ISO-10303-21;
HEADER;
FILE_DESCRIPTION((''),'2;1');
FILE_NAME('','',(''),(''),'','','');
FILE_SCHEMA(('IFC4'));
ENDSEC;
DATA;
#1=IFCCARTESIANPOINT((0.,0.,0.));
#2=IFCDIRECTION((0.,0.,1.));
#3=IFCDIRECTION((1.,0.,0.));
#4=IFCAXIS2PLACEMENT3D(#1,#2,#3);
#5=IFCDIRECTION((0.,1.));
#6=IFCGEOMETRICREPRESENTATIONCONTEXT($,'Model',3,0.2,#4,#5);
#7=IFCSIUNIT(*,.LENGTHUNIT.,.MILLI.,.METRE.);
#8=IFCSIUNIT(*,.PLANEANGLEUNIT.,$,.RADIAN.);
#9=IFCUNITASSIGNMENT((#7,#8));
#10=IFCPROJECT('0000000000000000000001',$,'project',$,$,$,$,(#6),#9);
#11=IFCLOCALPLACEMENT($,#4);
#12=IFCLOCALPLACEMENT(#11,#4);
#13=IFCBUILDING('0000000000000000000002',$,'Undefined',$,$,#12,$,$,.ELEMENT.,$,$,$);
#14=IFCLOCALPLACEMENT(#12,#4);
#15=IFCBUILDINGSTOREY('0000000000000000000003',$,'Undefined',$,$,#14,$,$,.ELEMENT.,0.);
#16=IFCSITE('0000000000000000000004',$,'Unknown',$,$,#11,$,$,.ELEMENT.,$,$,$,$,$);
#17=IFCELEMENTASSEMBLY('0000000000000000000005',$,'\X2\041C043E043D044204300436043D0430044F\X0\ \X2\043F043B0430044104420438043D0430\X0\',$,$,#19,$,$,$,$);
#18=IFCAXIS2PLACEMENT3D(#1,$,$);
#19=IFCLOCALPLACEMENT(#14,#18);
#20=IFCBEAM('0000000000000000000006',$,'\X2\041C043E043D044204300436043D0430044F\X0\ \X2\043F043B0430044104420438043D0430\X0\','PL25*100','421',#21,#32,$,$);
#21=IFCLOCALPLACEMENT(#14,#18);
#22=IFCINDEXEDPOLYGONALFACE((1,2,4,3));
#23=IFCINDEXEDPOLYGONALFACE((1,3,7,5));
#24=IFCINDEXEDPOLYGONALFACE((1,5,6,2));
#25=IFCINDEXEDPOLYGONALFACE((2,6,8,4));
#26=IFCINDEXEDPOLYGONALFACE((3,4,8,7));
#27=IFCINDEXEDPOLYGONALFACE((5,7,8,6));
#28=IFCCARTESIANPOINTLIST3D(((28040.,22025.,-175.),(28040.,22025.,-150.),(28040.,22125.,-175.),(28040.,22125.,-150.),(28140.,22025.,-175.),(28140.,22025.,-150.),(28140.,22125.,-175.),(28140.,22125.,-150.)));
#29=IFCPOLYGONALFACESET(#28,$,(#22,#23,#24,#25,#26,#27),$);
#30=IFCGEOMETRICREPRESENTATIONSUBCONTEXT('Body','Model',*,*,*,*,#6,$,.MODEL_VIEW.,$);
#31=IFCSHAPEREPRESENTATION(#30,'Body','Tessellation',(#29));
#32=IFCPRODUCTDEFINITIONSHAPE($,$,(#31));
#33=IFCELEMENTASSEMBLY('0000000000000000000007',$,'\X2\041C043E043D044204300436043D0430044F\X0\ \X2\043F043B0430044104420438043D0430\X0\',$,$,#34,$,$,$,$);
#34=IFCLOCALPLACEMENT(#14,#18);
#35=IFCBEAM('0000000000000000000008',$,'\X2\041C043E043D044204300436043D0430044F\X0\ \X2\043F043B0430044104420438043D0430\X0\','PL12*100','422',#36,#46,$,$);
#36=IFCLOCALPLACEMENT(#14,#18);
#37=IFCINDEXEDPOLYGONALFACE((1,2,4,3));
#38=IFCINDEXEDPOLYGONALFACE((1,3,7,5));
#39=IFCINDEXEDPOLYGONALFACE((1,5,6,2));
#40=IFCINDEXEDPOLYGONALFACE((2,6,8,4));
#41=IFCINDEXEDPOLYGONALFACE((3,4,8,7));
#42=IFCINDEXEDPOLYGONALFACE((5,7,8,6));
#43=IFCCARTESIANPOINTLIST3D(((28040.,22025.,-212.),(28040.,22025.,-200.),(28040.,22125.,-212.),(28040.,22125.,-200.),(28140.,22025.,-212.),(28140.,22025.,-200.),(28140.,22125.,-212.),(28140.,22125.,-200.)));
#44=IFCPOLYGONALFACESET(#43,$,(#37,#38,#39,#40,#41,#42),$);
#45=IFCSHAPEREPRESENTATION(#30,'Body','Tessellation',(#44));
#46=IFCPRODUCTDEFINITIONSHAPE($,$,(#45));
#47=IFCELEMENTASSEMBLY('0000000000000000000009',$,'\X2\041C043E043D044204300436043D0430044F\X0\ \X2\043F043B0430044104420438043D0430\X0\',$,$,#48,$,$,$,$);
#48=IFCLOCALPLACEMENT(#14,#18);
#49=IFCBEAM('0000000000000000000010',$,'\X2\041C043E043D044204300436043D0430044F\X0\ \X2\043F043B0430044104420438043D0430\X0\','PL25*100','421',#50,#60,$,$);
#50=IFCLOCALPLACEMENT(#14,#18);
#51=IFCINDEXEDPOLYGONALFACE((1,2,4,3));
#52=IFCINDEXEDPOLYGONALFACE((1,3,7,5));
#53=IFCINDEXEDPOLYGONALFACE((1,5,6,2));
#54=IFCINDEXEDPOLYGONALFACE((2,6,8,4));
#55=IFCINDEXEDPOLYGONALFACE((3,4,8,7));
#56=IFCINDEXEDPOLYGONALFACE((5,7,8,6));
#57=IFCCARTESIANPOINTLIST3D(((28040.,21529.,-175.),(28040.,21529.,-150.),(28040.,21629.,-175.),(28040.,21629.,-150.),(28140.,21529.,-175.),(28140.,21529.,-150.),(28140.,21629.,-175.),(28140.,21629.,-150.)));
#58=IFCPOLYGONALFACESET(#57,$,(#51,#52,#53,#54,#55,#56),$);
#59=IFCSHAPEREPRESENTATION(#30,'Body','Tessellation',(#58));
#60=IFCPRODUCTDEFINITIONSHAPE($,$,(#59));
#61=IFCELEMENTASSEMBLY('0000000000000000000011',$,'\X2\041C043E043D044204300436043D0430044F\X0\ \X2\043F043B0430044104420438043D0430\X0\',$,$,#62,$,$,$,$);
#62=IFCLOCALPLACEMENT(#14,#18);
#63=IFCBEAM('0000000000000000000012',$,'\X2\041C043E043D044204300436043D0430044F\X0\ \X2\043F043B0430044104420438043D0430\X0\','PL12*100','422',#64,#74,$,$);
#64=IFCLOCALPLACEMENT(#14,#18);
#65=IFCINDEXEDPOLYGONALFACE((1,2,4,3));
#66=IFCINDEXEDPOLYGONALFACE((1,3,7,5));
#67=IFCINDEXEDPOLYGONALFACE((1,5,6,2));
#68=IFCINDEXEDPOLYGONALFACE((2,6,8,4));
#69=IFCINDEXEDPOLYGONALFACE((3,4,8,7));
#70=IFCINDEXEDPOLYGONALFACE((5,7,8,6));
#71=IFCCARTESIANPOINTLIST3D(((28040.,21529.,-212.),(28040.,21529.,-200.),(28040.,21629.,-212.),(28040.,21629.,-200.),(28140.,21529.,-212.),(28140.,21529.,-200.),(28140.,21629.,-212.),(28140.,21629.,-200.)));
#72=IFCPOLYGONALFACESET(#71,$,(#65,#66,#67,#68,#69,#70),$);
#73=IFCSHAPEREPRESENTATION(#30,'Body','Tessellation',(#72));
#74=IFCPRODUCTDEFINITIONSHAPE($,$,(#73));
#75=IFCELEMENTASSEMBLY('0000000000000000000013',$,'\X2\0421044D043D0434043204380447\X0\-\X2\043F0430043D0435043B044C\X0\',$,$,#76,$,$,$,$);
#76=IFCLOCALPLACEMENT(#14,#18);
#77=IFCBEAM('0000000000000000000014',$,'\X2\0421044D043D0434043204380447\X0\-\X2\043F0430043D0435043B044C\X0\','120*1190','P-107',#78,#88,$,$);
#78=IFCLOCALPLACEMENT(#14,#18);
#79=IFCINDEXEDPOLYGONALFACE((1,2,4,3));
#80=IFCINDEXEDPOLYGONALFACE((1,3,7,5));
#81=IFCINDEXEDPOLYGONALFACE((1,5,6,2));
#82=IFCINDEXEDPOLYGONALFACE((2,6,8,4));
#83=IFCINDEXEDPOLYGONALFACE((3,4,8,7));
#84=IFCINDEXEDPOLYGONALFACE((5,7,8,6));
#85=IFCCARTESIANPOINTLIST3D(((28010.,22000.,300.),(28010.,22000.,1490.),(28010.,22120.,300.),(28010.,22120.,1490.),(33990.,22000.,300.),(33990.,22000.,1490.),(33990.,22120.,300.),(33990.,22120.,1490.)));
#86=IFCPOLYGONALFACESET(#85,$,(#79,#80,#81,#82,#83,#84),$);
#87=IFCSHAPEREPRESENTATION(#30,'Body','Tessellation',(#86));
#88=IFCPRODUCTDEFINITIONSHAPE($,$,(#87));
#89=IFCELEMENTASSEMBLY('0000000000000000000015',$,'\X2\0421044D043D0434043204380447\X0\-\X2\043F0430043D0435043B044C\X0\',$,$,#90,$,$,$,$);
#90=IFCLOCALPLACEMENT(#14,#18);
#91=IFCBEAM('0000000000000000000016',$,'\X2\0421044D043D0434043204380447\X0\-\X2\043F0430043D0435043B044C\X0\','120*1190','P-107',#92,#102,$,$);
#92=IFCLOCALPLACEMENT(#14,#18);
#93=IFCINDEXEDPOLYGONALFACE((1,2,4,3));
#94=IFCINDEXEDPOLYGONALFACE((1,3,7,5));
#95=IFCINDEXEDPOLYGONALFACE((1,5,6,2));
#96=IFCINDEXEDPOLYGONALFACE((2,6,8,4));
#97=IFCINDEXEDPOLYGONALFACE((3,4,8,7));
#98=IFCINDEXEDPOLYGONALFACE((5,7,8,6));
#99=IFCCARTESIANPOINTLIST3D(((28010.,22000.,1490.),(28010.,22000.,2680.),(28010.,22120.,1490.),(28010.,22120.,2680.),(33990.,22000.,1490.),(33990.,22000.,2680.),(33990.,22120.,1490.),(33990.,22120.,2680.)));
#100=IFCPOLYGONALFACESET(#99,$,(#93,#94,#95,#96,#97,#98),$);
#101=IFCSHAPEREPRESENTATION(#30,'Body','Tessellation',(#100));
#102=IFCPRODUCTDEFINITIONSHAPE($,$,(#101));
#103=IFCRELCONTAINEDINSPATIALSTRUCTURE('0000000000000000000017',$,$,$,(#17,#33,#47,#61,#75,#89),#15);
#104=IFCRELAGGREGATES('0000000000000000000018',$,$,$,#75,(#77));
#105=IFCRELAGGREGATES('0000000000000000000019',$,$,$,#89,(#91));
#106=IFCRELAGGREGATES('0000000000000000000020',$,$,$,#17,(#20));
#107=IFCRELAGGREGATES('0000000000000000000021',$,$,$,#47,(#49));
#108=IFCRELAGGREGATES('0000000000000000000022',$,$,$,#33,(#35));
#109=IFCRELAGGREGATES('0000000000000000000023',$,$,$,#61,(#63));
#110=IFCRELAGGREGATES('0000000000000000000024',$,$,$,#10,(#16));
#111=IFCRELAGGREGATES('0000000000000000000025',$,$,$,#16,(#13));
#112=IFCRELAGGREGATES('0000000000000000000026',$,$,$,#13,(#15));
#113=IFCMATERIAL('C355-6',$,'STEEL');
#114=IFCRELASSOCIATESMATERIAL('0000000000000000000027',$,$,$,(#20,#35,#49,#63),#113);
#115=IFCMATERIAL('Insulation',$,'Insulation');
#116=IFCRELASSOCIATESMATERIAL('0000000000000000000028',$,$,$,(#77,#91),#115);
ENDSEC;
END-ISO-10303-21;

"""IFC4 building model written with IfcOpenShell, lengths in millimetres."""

from ifc_helpers import new_model, si_unit, direction, frame, origin_with_axes, place, context, subcontext, project, spatial, line, indexed_curve, outline, extrude, material, element, aggregate, save


model = new_model("IFC4")

# Units and contexts
model_context = context("Model", 3, precision=0.2, world=origin_with_axes(), true_north=direction((0.0, 1.0)))
body_context = subcontext(model_context, "Body", "Model", "MODEL_VIEW")
ifc_project = project(units=[si_unit("LENGTHUNIT", "METRE", prefix="MILLI"), si_unit("PLANEANGLEUNIT", "RADIAN")], contexts=[model_context])

# Site, building, storey
site_placement = place(None, origin_with_axes())
site = spatial("IfcSite", under=ifc_project, at=site_placement, Name="Unknown", CompositionType="ELEMENT")
building_placement = place(site_placement, origin_with_axes())
building = spatial("IfcBuilding", under=site, at=building_placement, Name="Undefined", CompositionType="ELEMENT")
storey_placement = place(building_placement, origin_with_axes())
storey = spatial("IfcBuildingStorey", under=building, at=storey_placement, Name="Undefined", CompositionType="ELEMENT", Elevation=0.0)

# Element assemblies, beams
assembly_1_placement = place(storey_placement, frame((28140.0, 22075.0, -162.5), z_axis=(0.0, 0.0, -1.0), x_axis=(-1.0, 0.0, 0.0)))
assembly_1 = element("IfcElementAssembly", 1, at=assembly_1_placement, inside=storey, Name="Монтажная пластина")
ifc_material_1 = material(Name="C355-6", Category="STEEL")
beam_1_placement = place(assembly_1_placement, origin_with_axes())
beam_1 = element("IfcBeam", 2, at=beam_1_placement, material=ifc_material_1, Name="Монтажная пластина", Description="PL25*100", ObjectType="421", context=body_context, shape_type="SolidModel", body=[
    extrude(outline(indexed_curve([(-12.5, -50.0), (12.5, -50.0), (12.5, 50.0), (-12.5, 50.0)], segments=[line(1, 2, 3, 4, 1)])), frame((0.0, 0.0, 0.0), z_axis=(-1.0, 0.0, 0.0), x_axis=(0.0, 0.0, 1.0)), (0.0, 0.0, -1.0), 100.0),
])
assembly_2_placement = place(storey_placement, frame((28140.0, 22075.0, -206.0), z_axis=(0.0, 0.0, -1.0), x_axis=(-1.0, 0.0, 0.0)))
assembly_2 = element("IfcElementAssembly", 3, at=assembly_2_placement, inside=storey, Name="Монтажная пластина")
beam_2_placement = place(assembly_2_placement, origin_with_axes())
beam_2 = element("IfcBeam", 4, at=beam_2_placement, material=ifc_material_1, Name="Монтажная пластина", Description="PL12*100", ObjectType="422", context=body_context, shape_type="SolidModel", body=[
    extrude(outline(indexed_curve([(-6.0, -50.0), (6.0, -50.0), (6.0, 50.0), (-6.0, 50.0)], segments=[line(1, 2, 3, 4, 1)])), frame((0.0, 0.0, 0.0), z_axis=(-1.0, 0.0, 0.0), x_axis=(0.0, 0.0, 1.0)), (0.0, 0.0, -1.0), 100.0),
])
assembly_3_placement = place(storey_placement, frame((28140.0, 21579.0, -162.5), z_axis=(0.0, 0.0, -1.0), x_axis=(-1.0, 0.0, 0.0)))
assembly_3 = element("IfcElementAssembly", 5, at=assembly_3_placement, inside=storey, Name="Монтажная пластина")
beam_3_placement = place(assembly_3_placement, origin_with_axes())
beam_3 = element("IfcBeam", 6, at=beam_3_placement, material=ifc_material_1, Name="Монтажная пластина", Description="PL25*100", ObjectType="421", context=body_context, shape_type="SolidModel", body=[
    extrude(outline(indexed_curve([(-12.5, -50.0), (12.5, -50.0), (12.5, 50.0), (-12.5, 50.0)], segments=[line(1, 2, 3, 4, 1)])), frame((0.0, 0.0, 0.0), z_axis=(-1.0, 0.0, 0.0), x_axis=(0.0, 0.0, 1.0)), (0.0, 0.0, -1.0), 100.0),
])
assembly_4_placement = place(storey_placement, frame((28140.0, 21579.0, -206.0), z_axis=(0.0, 0.0, -1.0), x_axis=(-1.0, 0.0, 0.0)))
assembly_4 = element("IfcElementAssembly", 7, at=assembly_4_placement, inside=storey, Name="Монтажная пластина")
beam_4_placement = place(assembly_4_placement, origin_with_axes())
beam_4 = element("IfcBeam", 8, at=beam_4_placement, material=ifc_material_1, Name="Монтажная пластина", Description="PL12*100", ObjectType="422", context=body_context, shape_type="SolidModel", body=[
    extrude(outline(indexed_curve([(-6.0, -50.0), (6.0, -50.0), (6.0, 50.0), (-6.0, 50.0)], segments=[line(1, 2, 3, 4, 1)])), frame((0.0, 0.0, 0.0), z_axis=(-1.0, 0.0, 0.0), x_axis=(0.0, 0.0, 1.0)), (0.0, 0.0, -1.0), 100.0),
])
assembly_5_placement = place(storey_placement, frame((28010.0, 22060.0, 895.0), z_axis=(0.0, 0.0, -1.0), x_axis=(1.0, 0.0, 0.0)))
assembly_5 = element("IfcElementAssembly", 9, at=assembly_5_placement, inside=storey, Name="Сэндвич-панель")
ifc_material_2 = material(Name="Insulation", Category="Insulation")
beam_5_placement = place(assembly_5_placement, origin_with_axes())
beam_5 = element("IfcBeam", 10, at=beam_5_placement, material=ifc_material_2, Name="Сэндвич-панель", Description="120*1190", ObjectType="P-107", context=body_context, shape_type="SolidModel", body=[
    extrude(outline(indexed_curve([(-595.0, -60.0), (595.0, -60.0), (595.0, 60.0), (-595.0, 60.0)], segments=[line(1, 2, 3, 4, 1)])), frame((0.0, 0.0, 0.0), z_axis=(-1.0, 0.0, 0.0), x_axis=(0.0, 0.0, 1.0)), (0.0, 0.0, -1.0), 5980.0),
])
aggregate(assembly_5, [beam_5])
assembly_6_placement = place(storey_placement, frame((28010.0, 22060.0, 2085.0), z_axis=(0.0, 0.0, -1.0), x_axis=(1.0, 0.0, 0.0)))
assembly_6 = element("IfcElementAssembly", 11, at=assembly_6_placement, inside=storey, Name="Сэндвич-панель")
beam_6_placement = place(assembly_6_placement, origin_with_axes())
beam_6 = element("IfcBeam", 12, at=beam_6_placement, material=ifc_material_2, Name="Сэндвич-панель", Description="120*1190", ObjectType="P-107", context=body_context, shape_type="SolidModel", body=[
    extrude(outline(indexed_curve([(-595.0, -60.0), (595.0, -60.0), (595.0, 60.0), (-595.0, 60.0)], segments=[line(1, 2, 3, 4, 1)])), frame((0.0, 0.0, 0.0), z_axis=(-1.0, 0.0, 0.0), x_axis=(0.0, 0.0, 1.0)), (0.0, 0.0, -1.0), 5980.0),
])
aggregate(assembly_6, [beam_6])

aggregate(assembly_1, [beam_1])
aggregate(assembly_3, [beam_3])
aggregate(assembly_2, [beam_2])
aggregate(assembly_4, [beam_4])

save(model, "model.ifc")
